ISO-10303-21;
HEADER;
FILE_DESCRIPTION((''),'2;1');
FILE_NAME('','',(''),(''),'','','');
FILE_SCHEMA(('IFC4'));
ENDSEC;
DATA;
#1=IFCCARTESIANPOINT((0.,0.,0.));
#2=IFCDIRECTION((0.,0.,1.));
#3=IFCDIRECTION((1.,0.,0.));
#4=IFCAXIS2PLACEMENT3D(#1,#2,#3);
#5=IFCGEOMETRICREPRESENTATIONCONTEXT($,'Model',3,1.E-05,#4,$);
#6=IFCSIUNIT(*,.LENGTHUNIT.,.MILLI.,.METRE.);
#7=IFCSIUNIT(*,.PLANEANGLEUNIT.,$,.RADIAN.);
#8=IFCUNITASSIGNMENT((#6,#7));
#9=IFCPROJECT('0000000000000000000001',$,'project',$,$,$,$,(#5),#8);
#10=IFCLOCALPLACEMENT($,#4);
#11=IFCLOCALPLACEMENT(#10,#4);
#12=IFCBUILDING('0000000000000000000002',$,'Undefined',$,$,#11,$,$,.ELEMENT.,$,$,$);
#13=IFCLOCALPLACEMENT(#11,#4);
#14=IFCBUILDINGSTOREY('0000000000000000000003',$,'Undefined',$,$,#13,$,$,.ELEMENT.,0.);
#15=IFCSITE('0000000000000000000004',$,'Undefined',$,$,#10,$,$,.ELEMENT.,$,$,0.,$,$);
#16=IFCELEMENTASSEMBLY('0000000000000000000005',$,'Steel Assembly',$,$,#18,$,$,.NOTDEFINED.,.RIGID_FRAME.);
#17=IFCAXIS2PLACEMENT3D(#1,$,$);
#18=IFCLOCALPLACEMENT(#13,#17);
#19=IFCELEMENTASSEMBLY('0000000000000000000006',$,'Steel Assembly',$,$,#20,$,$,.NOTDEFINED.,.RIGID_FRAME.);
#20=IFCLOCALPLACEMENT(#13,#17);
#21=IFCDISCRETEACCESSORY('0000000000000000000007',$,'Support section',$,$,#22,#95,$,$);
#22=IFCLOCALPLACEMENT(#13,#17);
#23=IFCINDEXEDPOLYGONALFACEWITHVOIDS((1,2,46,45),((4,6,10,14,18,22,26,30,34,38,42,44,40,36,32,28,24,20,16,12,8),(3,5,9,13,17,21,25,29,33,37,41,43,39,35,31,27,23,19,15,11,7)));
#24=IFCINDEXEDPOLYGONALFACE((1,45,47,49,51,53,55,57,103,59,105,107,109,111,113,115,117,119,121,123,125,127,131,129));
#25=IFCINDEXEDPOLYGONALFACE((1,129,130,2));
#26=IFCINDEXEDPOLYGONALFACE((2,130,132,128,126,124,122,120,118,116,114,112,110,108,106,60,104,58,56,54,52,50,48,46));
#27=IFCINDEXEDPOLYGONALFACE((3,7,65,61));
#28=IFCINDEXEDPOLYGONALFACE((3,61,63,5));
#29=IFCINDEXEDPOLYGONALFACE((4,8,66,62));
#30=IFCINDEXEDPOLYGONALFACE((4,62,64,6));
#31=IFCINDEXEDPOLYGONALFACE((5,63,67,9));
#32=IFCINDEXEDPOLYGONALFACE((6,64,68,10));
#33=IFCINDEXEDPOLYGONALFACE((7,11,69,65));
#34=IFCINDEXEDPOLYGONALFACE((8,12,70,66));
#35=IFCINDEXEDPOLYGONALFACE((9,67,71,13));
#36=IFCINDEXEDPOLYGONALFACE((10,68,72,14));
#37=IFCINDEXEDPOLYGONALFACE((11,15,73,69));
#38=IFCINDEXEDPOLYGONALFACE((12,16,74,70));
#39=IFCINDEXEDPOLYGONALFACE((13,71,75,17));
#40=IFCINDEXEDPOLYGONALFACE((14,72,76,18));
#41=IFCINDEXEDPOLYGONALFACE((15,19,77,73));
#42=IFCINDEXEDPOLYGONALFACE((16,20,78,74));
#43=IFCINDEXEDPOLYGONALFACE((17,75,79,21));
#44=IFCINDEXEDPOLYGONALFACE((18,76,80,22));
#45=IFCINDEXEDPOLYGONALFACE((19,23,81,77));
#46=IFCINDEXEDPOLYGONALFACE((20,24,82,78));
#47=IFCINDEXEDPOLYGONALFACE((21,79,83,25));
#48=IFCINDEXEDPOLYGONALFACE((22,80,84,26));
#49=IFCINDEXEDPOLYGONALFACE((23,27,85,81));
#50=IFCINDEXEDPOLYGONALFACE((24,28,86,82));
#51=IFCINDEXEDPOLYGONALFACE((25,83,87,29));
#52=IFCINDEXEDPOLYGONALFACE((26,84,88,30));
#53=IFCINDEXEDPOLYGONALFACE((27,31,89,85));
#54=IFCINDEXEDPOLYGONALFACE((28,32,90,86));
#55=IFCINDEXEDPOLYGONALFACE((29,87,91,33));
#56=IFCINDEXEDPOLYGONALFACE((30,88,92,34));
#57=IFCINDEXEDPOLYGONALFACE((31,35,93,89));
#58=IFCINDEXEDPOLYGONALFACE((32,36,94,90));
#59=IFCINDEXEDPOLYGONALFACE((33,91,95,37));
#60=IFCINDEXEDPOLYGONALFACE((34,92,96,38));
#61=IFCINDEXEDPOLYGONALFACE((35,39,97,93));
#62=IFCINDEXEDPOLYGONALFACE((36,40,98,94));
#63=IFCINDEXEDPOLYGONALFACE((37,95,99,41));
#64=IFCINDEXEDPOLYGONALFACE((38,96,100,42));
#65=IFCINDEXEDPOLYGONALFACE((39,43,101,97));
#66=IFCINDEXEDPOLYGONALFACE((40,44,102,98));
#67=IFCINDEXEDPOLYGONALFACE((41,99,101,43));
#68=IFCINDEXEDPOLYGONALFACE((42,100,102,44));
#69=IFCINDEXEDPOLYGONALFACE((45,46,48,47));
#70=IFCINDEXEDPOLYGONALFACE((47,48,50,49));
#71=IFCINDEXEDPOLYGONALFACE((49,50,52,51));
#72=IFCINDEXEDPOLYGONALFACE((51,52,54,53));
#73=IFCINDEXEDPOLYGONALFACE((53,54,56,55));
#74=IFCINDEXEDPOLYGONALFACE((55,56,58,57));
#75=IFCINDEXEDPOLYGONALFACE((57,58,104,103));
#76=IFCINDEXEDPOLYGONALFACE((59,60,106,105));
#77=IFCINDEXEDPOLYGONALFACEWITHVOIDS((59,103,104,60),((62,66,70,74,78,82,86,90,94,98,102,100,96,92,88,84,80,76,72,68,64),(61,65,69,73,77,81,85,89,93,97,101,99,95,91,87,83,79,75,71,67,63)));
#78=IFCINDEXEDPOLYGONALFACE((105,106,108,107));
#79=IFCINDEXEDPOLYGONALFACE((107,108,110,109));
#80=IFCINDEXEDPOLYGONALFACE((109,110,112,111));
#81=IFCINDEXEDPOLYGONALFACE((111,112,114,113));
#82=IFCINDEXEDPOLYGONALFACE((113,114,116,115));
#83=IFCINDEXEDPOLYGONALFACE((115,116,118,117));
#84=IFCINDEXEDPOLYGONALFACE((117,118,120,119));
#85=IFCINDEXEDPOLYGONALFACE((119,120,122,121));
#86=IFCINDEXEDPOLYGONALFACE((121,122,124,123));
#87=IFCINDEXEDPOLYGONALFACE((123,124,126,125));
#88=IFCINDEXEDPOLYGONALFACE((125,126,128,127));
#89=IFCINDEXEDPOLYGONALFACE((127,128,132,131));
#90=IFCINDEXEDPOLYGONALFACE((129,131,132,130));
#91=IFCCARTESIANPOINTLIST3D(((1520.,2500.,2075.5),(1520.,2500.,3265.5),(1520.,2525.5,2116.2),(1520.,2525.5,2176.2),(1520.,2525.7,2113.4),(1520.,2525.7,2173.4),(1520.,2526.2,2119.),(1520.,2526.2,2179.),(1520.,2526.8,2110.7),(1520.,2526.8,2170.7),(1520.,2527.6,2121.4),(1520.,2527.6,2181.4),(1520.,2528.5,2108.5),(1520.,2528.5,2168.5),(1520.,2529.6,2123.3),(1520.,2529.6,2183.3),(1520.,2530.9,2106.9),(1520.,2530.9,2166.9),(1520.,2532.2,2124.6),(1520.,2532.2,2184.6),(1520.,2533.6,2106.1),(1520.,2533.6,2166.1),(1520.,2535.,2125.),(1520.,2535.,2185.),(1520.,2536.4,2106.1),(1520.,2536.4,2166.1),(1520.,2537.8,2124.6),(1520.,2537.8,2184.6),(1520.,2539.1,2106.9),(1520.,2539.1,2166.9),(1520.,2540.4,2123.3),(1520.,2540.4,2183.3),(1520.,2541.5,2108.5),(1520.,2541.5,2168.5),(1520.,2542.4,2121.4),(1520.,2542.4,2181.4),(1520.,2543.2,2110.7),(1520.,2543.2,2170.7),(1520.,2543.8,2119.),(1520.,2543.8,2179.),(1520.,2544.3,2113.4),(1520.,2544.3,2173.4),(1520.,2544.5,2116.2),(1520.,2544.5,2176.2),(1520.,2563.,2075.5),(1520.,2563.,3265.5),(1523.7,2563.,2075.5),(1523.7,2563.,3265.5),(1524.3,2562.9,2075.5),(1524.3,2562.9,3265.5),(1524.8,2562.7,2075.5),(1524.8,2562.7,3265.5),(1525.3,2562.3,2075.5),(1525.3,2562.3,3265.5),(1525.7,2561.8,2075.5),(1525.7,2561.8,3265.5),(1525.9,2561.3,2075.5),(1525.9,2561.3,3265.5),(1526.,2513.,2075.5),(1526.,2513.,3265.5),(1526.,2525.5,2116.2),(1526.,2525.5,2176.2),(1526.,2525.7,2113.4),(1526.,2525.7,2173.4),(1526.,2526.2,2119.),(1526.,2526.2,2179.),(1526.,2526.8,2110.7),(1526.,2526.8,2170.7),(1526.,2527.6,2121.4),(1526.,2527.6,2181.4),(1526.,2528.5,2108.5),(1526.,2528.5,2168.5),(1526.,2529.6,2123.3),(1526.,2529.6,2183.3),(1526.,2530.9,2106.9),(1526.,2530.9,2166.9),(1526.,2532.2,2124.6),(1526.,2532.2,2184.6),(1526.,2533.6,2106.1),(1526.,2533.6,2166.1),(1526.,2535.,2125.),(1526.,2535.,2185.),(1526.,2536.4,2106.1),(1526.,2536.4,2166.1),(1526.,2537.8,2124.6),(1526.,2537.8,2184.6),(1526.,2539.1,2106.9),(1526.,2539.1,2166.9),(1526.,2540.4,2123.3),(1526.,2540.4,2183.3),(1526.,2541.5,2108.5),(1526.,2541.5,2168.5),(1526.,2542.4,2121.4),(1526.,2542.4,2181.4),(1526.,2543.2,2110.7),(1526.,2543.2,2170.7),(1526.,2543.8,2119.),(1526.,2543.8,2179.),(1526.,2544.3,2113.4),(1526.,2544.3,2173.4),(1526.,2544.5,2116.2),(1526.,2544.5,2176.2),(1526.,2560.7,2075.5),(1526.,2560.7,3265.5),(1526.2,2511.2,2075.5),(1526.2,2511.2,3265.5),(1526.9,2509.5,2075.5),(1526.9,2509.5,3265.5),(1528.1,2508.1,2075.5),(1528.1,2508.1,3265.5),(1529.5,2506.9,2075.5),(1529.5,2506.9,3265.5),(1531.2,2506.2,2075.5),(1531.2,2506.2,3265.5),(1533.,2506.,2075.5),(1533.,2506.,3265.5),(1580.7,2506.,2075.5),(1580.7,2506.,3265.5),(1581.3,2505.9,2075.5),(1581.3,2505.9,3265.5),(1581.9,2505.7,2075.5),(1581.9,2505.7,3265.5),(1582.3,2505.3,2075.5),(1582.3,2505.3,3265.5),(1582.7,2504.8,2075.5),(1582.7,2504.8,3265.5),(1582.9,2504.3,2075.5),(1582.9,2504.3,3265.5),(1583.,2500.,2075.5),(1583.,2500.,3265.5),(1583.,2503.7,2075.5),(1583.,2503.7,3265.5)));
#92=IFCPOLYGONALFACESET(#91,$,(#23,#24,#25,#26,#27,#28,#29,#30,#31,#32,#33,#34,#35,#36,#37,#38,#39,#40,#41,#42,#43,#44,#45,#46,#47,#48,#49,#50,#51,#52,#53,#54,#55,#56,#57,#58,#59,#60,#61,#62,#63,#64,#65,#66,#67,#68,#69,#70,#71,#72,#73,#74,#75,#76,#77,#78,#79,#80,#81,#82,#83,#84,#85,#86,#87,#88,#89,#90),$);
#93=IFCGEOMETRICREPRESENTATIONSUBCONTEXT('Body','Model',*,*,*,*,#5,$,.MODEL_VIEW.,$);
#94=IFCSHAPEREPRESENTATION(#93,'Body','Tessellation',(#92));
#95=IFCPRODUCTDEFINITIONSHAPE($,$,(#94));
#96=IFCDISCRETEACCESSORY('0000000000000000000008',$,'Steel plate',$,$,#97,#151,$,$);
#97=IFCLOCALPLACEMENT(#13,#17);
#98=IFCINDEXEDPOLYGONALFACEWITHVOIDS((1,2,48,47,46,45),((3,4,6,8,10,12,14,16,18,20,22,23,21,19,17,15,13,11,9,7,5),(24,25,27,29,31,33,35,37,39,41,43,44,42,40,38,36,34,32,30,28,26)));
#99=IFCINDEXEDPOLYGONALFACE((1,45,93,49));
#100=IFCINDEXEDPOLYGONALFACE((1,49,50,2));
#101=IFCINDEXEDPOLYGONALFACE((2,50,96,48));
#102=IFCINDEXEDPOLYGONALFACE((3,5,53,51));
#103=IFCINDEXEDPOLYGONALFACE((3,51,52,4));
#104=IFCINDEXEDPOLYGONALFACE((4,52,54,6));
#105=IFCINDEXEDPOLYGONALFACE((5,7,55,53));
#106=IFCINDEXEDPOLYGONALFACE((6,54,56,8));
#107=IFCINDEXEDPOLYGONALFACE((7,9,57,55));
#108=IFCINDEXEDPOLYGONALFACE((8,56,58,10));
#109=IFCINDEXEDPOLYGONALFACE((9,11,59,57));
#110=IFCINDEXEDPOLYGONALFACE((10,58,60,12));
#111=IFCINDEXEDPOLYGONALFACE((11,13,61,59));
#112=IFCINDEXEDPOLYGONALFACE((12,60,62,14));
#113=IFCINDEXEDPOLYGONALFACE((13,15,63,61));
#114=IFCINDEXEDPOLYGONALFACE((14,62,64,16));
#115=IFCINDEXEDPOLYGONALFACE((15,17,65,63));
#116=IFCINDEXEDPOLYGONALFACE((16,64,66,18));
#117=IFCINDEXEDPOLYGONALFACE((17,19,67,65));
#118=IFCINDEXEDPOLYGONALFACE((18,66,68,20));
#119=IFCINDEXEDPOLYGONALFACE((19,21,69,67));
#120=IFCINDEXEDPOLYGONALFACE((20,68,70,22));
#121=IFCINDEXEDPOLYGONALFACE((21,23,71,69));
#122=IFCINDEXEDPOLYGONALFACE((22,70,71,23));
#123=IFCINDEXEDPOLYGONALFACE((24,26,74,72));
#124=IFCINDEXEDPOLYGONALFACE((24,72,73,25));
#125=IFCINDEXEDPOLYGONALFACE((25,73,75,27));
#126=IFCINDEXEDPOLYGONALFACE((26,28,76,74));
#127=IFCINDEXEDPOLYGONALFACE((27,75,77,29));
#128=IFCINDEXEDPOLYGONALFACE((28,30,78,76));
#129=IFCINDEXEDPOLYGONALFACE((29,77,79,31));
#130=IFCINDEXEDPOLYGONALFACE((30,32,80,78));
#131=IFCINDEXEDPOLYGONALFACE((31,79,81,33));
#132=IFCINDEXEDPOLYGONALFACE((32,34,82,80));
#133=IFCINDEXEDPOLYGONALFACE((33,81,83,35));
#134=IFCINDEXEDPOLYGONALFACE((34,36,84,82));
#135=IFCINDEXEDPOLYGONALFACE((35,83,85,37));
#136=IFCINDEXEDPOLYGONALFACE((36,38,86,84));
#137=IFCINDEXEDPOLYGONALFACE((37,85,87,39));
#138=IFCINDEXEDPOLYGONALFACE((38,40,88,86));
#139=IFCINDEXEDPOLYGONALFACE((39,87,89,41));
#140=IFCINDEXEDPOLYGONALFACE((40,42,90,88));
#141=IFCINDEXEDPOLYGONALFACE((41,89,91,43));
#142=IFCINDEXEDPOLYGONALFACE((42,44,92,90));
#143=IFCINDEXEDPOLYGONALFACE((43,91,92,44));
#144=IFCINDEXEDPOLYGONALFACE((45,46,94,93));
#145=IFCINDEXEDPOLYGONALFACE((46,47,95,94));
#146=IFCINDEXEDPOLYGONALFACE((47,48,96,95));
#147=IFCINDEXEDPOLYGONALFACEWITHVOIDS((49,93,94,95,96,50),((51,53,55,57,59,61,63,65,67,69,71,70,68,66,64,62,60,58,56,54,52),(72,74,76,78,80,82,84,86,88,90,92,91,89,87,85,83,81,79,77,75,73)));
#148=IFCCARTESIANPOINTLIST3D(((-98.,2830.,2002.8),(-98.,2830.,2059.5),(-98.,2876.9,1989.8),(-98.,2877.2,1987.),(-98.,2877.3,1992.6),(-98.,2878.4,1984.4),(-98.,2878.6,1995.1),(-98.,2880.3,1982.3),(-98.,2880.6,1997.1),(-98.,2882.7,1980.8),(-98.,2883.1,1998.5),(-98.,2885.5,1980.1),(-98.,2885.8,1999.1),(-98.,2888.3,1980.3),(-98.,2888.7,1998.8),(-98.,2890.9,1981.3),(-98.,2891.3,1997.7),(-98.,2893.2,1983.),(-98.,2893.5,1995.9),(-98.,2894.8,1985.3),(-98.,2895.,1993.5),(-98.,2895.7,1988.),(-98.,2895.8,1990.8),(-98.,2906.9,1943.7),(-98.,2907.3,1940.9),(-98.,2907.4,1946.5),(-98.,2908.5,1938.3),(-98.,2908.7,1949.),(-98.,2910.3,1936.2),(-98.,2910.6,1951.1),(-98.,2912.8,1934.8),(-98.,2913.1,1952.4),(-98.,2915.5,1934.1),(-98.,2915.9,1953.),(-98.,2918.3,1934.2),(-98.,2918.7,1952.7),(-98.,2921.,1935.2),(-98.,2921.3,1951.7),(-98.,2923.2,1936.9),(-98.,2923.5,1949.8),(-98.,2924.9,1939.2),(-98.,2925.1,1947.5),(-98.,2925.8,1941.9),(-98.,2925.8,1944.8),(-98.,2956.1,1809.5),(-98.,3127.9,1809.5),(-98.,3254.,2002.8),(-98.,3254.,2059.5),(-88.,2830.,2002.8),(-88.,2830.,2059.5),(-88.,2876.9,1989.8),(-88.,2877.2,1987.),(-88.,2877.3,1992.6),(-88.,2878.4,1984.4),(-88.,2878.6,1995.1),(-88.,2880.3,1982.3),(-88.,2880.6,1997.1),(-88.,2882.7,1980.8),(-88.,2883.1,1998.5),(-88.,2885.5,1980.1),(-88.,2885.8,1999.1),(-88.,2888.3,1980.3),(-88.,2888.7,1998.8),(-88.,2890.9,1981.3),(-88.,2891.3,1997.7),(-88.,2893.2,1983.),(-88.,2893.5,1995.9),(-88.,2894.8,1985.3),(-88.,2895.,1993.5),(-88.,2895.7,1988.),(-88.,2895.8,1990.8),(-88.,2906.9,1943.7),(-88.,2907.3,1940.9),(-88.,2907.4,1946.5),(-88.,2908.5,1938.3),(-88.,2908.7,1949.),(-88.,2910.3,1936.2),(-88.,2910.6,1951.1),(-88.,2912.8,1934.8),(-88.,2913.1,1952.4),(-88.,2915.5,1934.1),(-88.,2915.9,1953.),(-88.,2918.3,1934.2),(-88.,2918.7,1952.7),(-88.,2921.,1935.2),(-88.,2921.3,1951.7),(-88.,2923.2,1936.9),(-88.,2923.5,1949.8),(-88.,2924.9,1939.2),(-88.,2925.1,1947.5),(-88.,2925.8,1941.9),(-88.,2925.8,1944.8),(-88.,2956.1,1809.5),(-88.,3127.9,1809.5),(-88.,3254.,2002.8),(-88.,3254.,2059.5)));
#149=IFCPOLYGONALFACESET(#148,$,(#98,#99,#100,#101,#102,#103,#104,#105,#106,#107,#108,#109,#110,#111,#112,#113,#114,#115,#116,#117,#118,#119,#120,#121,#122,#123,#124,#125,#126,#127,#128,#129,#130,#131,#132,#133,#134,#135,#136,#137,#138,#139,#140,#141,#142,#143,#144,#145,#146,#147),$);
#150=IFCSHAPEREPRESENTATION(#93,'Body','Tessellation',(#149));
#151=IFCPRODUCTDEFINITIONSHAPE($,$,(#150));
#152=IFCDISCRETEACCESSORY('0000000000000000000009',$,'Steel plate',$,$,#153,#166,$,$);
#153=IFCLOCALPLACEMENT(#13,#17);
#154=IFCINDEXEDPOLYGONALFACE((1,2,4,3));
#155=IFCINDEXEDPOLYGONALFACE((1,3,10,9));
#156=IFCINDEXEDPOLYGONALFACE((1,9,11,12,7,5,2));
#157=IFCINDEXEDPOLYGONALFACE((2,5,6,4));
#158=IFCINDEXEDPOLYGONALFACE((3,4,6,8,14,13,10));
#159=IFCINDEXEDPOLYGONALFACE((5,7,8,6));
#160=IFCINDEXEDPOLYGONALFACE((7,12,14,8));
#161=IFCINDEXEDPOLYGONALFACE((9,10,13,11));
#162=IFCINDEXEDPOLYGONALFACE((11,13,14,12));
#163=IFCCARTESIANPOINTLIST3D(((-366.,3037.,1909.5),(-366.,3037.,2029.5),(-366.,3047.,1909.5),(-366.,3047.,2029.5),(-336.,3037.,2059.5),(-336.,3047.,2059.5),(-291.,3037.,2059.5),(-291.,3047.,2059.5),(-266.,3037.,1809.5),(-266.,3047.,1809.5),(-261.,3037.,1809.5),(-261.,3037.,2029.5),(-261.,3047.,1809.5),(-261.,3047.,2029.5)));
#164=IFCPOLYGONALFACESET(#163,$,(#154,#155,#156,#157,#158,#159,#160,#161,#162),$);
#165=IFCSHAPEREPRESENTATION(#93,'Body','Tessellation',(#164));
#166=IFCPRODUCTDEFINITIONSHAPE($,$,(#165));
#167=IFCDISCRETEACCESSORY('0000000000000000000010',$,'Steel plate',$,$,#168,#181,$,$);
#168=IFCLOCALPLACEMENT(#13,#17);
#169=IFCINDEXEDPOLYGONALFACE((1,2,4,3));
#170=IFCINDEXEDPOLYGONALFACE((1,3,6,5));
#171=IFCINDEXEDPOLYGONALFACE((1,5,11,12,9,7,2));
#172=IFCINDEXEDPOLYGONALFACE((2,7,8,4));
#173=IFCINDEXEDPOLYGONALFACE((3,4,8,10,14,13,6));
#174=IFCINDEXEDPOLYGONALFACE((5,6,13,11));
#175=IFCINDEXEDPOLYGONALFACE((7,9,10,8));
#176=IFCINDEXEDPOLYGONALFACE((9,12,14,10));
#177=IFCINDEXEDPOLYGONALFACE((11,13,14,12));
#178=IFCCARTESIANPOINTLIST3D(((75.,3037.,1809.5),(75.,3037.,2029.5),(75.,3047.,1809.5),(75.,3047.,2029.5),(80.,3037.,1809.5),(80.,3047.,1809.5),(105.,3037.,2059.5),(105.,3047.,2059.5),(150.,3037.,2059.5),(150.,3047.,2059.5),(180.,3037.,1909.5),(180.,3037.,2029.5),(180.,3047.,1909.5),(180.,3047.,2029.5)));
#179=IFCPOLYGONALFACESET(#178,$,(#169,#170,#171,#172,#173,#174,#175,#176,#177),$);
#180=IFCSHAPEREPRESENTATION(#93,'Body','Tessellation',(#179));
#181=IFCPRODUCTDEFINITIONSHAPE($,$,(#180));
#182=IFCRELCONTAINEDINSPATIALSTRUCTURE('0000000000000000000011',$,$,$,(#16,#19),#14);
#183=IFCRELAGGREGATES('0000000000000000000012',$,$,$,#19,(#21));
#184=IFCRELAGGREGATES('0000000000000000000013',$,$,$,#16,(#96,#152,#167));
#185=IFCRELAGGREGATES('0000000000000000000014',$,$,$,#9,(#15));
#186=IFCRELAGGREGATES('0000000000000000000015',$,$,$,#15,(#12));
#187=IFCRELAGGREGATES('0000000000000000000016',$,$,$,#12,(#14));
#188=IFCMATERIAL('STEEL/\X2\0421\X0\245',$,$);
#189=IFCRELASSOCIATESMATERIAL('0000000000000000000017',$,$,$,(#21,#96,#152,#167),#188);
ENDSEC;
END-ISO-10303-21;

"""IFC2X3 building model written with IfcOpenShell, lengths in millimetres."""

from ifc_helpers import new_model, si_unit, frame, origin_with_axes, origin_2d_with_axis, place, context, subcontext, project, spatial, polyline, circle, l_section, outline, extrude, source, transform, mapped, material, element, aggregate, save


model = new_model("IFC2X3")

# Units and contexts
model_context = context("Model", 3, precision=1e-05, world=origin_with_axes())
body_context = subcontext(model_context, "Body", "Model", "MODEL_VIEW")
ifc_project = project(units=[si_unit("LENGTHUNIT", "METRE", prefix="MILLI"), si_unit("PLANEANGLEUNIT", "RADIAN")], contexts=[model_context])

# Site, building, storey
site_placement = place(None, origin_with_axes())
site = spatial("IfcSite", under=ifc_project, at=site_placement, Name="Undefined", CompositionType="ELEMENT", RefElevation=0.0)
building_placement = place(site_placement, origin_with_axes())
building = spatial("IfcBuilding", under=site, at=building_placement, Name="Undefined", CompositionType="ELEMENT")
storey_placement = place(building_placement, origin_with_axes())
storey = spatial("IfcBuildingStorey", under=building, at=storey_placement, Name="Undefined", CompositionType="ELEMENT", Elevation=0.0)

# Element assembly
assembly_1_placement = place(storey_placement, origin_with_axes())
assembly_1 = element("IfcElementAssembly", 1, at=assembly_1_placement, inside=storey, Name="Steel Assembly", AssemblyPlace="NOTDEFINED", PredefinedType="RIGID_FRAME")
ifc_material_1 = material(Name="STEEL/С245")

# Element assembly, discrete accessory, opening
assembly_2_placement = place(storey_placement, origin_with_axes())
assembly_2 = element("IfcElementAssembly", 2, at=assembly_2_placement, inside=storey, Name="Steel Assembly", AssemblyPlace="NOTDEFINED", PredefinedType="RIGID_FRAME")
discrete_accessory_1_placement = place(assembly_2_placement, frame((1551.5, 2531.5, 2075.5), z_axis=(0.0, 0.0, 1.0), x_axis=(1.0, 0.0, 0.0)))
discrete_accessory_1 = element("IfcDiscreteAccessory", 3, at=discrete_accessory_1_placement, material=ifc_material_1, Name="Support section", context=body_context, shape_type="SweptSolid", body=[
    extrude(l_section(Depth=63.0, Width=63.0, Thickness=6.0, FilletRadius=7.0, EdgeRadius=2.3, at=origin_2d_with_axis()), frame((0.0, 0.0, 1190.0), z_axis=(0.0, 0.0, -1.0), x_axis=(0.0, 1.0, 0.0)), (0.0, 0.0, 1.0), 1190.0),
])
shared_shape_1 = source(origin_with_axes(), body_context, "Body", "SweptSolid", [
    extrude(circle(Radius=9.5, at=origin_2d_with_axis()), frame((0.0, -0.1, 0.0), z_axis=(0.0, 1.0, 0.0), x_axis=(1.0, 0.0, 0.0)), (0.0, 0.0, 1.0), 6.2),
])
opening_1_placement = place(assembly_2_placement, frame((1520.0, 2535.0, 2115.5), z_axis=(0.0, 1.0, 0.0), x_axis=(0.0, 0.0, 1.0)))
element("IfcOpeningElement", 4, at=opening_1_placement, cuts=discrete_accessory_1, ObjectType="Opening", context=body_context, shape_type="MappedRepresentation", body=[
    mapped(shared_shape_1, transform((0.0, 0.0, 0.0))),
    mapped(shared_shape_1, transform((60.0, 0.0, 0.0))),
])
aggregate(assembly_2, [discrete_accessory_1])

# Discrete accessory, opening
discrete_accessory_2_placement = place(assembly_1_placement, frame((-93.0, 2830.0, 2059.5), z_axis=(-1.0, 0.0, 0.0), x_axis=(0.0, 1.0, 0.0)))
discrete_accessory_2 = element("IfcDiscreteAccessory", 5, at=discrete_accessory_2_placement, material=ifc_material_1, Name="Steel plate", context=body_context, shape_type="SweptSolid", body=[
    extrude(outline(polyline([(0.0, 0.0), (424.0, 0.0), (424.0, 56.7), (297.9, 250.0), (126.1, 250.0), (0.0, 56.7), (0.0, 0.0)])), frame((0.0, 0.0, -5.0), z_axis=(0.0, 0.0, 1.0), x_axis=(1.0, 0.0, 0.0)), (0.0, 0.0, 1.0), 10.0),
])
shared_shape_2 = source(origin_with_axes(), body_context, "Body", "SweptSolid", [
    extrude(circle(Radius=9.5, at=origin_2d_with_axis()), frame((0.0, -14.1, 0.0), z_axis=(0.0, 1.0, 0.0), x_axis=(1.0, 0.0, 0.0)), (0.0, 0.0, 1.0), 24.3),
])
opening_2_placement = place(assembly_1_placement, frame((-84.0, 2901.4, 1966.6), z_axis=(0.0, -0.546313, 0.837581), x_axis=(0.0, -0.837581, -0.546313)))
element("IfcOpeningElement", 6, at=opening_2_placement, cuts=discrete_accessory_2, ObjectType="Opening", context=body_context, shape_type="MappedRepresentation", body=[
    mapped(shared_shape_2, transform((0.0, 0.0, -27.5))),
    mapped(shared_shape_2, transform((0.0, 0.0, 27.5))),
])

# Discrete accessories
discrete_accessory_3_placement = place(assembly_1_placement, frame((-261.0, 3042.0, 2059.5), z_axis=(0.0, -1.0, 0.0), x_axis=(-1.0, 0.0, 0.0)))
discrete_accessory_3 = element("IfcDiscreteAccessory", 7, at=discrete_accessory_3_placement, material=ifc_material_1, Name="Steel plate", context=body_context, shape_type="SweptSolid", body=[
    extrude(outline(polyline([(0.0, 30.0), (30.0, 0.0), (75.0, 0.0), (105.0, 30.0), (105.0, 150.0), (5.0, 250.0), (0.0, 250.0), (0.0, 30.0)])), frame((0.0, 0.0, -5.0), z_axis=(0.0, 0.0, 1.0), x_axis=(1.0, 0.0, 0.0)), (0.0, 0.0, 1.0), 10.0),
])
discrete_accessory_4_placement = place(assembly_1_placement, frame((75.0, 3042.0, 2059.5), z_axis=(0.0, 1.0, 0.0), x_axis=(1.0, 0.0, 0.0)))
discrete_accessory_4 = element("IfcDiscreteAccessory", 8, at=discrete_accessory_4_placement, material=ifc_material_1, Name="Steel plate", context=body_context, shape_type="SweptSolid", body=[
    extrude(outline(polyline([(0.0, 30.0), (30.0, 0.0), (75.0, 0.0), (105.0, 30.0), (105.0, 150.0), (5.0, 250.0), (0.0, 250.0), (0.0, 30.0)])), frame((0.0, 0.0, -5.0), z_axis=(0.0, 0.0, 1.0), x_axis=(1.0, 0.0, 0.0)), (0.0, 0.0, 1.0), 10.0),
])
aggregate(assembly_1, [discrete_accessory_2, discrete_accessory_3, discrete_accessory_4])

save(model, "model.ifc")
